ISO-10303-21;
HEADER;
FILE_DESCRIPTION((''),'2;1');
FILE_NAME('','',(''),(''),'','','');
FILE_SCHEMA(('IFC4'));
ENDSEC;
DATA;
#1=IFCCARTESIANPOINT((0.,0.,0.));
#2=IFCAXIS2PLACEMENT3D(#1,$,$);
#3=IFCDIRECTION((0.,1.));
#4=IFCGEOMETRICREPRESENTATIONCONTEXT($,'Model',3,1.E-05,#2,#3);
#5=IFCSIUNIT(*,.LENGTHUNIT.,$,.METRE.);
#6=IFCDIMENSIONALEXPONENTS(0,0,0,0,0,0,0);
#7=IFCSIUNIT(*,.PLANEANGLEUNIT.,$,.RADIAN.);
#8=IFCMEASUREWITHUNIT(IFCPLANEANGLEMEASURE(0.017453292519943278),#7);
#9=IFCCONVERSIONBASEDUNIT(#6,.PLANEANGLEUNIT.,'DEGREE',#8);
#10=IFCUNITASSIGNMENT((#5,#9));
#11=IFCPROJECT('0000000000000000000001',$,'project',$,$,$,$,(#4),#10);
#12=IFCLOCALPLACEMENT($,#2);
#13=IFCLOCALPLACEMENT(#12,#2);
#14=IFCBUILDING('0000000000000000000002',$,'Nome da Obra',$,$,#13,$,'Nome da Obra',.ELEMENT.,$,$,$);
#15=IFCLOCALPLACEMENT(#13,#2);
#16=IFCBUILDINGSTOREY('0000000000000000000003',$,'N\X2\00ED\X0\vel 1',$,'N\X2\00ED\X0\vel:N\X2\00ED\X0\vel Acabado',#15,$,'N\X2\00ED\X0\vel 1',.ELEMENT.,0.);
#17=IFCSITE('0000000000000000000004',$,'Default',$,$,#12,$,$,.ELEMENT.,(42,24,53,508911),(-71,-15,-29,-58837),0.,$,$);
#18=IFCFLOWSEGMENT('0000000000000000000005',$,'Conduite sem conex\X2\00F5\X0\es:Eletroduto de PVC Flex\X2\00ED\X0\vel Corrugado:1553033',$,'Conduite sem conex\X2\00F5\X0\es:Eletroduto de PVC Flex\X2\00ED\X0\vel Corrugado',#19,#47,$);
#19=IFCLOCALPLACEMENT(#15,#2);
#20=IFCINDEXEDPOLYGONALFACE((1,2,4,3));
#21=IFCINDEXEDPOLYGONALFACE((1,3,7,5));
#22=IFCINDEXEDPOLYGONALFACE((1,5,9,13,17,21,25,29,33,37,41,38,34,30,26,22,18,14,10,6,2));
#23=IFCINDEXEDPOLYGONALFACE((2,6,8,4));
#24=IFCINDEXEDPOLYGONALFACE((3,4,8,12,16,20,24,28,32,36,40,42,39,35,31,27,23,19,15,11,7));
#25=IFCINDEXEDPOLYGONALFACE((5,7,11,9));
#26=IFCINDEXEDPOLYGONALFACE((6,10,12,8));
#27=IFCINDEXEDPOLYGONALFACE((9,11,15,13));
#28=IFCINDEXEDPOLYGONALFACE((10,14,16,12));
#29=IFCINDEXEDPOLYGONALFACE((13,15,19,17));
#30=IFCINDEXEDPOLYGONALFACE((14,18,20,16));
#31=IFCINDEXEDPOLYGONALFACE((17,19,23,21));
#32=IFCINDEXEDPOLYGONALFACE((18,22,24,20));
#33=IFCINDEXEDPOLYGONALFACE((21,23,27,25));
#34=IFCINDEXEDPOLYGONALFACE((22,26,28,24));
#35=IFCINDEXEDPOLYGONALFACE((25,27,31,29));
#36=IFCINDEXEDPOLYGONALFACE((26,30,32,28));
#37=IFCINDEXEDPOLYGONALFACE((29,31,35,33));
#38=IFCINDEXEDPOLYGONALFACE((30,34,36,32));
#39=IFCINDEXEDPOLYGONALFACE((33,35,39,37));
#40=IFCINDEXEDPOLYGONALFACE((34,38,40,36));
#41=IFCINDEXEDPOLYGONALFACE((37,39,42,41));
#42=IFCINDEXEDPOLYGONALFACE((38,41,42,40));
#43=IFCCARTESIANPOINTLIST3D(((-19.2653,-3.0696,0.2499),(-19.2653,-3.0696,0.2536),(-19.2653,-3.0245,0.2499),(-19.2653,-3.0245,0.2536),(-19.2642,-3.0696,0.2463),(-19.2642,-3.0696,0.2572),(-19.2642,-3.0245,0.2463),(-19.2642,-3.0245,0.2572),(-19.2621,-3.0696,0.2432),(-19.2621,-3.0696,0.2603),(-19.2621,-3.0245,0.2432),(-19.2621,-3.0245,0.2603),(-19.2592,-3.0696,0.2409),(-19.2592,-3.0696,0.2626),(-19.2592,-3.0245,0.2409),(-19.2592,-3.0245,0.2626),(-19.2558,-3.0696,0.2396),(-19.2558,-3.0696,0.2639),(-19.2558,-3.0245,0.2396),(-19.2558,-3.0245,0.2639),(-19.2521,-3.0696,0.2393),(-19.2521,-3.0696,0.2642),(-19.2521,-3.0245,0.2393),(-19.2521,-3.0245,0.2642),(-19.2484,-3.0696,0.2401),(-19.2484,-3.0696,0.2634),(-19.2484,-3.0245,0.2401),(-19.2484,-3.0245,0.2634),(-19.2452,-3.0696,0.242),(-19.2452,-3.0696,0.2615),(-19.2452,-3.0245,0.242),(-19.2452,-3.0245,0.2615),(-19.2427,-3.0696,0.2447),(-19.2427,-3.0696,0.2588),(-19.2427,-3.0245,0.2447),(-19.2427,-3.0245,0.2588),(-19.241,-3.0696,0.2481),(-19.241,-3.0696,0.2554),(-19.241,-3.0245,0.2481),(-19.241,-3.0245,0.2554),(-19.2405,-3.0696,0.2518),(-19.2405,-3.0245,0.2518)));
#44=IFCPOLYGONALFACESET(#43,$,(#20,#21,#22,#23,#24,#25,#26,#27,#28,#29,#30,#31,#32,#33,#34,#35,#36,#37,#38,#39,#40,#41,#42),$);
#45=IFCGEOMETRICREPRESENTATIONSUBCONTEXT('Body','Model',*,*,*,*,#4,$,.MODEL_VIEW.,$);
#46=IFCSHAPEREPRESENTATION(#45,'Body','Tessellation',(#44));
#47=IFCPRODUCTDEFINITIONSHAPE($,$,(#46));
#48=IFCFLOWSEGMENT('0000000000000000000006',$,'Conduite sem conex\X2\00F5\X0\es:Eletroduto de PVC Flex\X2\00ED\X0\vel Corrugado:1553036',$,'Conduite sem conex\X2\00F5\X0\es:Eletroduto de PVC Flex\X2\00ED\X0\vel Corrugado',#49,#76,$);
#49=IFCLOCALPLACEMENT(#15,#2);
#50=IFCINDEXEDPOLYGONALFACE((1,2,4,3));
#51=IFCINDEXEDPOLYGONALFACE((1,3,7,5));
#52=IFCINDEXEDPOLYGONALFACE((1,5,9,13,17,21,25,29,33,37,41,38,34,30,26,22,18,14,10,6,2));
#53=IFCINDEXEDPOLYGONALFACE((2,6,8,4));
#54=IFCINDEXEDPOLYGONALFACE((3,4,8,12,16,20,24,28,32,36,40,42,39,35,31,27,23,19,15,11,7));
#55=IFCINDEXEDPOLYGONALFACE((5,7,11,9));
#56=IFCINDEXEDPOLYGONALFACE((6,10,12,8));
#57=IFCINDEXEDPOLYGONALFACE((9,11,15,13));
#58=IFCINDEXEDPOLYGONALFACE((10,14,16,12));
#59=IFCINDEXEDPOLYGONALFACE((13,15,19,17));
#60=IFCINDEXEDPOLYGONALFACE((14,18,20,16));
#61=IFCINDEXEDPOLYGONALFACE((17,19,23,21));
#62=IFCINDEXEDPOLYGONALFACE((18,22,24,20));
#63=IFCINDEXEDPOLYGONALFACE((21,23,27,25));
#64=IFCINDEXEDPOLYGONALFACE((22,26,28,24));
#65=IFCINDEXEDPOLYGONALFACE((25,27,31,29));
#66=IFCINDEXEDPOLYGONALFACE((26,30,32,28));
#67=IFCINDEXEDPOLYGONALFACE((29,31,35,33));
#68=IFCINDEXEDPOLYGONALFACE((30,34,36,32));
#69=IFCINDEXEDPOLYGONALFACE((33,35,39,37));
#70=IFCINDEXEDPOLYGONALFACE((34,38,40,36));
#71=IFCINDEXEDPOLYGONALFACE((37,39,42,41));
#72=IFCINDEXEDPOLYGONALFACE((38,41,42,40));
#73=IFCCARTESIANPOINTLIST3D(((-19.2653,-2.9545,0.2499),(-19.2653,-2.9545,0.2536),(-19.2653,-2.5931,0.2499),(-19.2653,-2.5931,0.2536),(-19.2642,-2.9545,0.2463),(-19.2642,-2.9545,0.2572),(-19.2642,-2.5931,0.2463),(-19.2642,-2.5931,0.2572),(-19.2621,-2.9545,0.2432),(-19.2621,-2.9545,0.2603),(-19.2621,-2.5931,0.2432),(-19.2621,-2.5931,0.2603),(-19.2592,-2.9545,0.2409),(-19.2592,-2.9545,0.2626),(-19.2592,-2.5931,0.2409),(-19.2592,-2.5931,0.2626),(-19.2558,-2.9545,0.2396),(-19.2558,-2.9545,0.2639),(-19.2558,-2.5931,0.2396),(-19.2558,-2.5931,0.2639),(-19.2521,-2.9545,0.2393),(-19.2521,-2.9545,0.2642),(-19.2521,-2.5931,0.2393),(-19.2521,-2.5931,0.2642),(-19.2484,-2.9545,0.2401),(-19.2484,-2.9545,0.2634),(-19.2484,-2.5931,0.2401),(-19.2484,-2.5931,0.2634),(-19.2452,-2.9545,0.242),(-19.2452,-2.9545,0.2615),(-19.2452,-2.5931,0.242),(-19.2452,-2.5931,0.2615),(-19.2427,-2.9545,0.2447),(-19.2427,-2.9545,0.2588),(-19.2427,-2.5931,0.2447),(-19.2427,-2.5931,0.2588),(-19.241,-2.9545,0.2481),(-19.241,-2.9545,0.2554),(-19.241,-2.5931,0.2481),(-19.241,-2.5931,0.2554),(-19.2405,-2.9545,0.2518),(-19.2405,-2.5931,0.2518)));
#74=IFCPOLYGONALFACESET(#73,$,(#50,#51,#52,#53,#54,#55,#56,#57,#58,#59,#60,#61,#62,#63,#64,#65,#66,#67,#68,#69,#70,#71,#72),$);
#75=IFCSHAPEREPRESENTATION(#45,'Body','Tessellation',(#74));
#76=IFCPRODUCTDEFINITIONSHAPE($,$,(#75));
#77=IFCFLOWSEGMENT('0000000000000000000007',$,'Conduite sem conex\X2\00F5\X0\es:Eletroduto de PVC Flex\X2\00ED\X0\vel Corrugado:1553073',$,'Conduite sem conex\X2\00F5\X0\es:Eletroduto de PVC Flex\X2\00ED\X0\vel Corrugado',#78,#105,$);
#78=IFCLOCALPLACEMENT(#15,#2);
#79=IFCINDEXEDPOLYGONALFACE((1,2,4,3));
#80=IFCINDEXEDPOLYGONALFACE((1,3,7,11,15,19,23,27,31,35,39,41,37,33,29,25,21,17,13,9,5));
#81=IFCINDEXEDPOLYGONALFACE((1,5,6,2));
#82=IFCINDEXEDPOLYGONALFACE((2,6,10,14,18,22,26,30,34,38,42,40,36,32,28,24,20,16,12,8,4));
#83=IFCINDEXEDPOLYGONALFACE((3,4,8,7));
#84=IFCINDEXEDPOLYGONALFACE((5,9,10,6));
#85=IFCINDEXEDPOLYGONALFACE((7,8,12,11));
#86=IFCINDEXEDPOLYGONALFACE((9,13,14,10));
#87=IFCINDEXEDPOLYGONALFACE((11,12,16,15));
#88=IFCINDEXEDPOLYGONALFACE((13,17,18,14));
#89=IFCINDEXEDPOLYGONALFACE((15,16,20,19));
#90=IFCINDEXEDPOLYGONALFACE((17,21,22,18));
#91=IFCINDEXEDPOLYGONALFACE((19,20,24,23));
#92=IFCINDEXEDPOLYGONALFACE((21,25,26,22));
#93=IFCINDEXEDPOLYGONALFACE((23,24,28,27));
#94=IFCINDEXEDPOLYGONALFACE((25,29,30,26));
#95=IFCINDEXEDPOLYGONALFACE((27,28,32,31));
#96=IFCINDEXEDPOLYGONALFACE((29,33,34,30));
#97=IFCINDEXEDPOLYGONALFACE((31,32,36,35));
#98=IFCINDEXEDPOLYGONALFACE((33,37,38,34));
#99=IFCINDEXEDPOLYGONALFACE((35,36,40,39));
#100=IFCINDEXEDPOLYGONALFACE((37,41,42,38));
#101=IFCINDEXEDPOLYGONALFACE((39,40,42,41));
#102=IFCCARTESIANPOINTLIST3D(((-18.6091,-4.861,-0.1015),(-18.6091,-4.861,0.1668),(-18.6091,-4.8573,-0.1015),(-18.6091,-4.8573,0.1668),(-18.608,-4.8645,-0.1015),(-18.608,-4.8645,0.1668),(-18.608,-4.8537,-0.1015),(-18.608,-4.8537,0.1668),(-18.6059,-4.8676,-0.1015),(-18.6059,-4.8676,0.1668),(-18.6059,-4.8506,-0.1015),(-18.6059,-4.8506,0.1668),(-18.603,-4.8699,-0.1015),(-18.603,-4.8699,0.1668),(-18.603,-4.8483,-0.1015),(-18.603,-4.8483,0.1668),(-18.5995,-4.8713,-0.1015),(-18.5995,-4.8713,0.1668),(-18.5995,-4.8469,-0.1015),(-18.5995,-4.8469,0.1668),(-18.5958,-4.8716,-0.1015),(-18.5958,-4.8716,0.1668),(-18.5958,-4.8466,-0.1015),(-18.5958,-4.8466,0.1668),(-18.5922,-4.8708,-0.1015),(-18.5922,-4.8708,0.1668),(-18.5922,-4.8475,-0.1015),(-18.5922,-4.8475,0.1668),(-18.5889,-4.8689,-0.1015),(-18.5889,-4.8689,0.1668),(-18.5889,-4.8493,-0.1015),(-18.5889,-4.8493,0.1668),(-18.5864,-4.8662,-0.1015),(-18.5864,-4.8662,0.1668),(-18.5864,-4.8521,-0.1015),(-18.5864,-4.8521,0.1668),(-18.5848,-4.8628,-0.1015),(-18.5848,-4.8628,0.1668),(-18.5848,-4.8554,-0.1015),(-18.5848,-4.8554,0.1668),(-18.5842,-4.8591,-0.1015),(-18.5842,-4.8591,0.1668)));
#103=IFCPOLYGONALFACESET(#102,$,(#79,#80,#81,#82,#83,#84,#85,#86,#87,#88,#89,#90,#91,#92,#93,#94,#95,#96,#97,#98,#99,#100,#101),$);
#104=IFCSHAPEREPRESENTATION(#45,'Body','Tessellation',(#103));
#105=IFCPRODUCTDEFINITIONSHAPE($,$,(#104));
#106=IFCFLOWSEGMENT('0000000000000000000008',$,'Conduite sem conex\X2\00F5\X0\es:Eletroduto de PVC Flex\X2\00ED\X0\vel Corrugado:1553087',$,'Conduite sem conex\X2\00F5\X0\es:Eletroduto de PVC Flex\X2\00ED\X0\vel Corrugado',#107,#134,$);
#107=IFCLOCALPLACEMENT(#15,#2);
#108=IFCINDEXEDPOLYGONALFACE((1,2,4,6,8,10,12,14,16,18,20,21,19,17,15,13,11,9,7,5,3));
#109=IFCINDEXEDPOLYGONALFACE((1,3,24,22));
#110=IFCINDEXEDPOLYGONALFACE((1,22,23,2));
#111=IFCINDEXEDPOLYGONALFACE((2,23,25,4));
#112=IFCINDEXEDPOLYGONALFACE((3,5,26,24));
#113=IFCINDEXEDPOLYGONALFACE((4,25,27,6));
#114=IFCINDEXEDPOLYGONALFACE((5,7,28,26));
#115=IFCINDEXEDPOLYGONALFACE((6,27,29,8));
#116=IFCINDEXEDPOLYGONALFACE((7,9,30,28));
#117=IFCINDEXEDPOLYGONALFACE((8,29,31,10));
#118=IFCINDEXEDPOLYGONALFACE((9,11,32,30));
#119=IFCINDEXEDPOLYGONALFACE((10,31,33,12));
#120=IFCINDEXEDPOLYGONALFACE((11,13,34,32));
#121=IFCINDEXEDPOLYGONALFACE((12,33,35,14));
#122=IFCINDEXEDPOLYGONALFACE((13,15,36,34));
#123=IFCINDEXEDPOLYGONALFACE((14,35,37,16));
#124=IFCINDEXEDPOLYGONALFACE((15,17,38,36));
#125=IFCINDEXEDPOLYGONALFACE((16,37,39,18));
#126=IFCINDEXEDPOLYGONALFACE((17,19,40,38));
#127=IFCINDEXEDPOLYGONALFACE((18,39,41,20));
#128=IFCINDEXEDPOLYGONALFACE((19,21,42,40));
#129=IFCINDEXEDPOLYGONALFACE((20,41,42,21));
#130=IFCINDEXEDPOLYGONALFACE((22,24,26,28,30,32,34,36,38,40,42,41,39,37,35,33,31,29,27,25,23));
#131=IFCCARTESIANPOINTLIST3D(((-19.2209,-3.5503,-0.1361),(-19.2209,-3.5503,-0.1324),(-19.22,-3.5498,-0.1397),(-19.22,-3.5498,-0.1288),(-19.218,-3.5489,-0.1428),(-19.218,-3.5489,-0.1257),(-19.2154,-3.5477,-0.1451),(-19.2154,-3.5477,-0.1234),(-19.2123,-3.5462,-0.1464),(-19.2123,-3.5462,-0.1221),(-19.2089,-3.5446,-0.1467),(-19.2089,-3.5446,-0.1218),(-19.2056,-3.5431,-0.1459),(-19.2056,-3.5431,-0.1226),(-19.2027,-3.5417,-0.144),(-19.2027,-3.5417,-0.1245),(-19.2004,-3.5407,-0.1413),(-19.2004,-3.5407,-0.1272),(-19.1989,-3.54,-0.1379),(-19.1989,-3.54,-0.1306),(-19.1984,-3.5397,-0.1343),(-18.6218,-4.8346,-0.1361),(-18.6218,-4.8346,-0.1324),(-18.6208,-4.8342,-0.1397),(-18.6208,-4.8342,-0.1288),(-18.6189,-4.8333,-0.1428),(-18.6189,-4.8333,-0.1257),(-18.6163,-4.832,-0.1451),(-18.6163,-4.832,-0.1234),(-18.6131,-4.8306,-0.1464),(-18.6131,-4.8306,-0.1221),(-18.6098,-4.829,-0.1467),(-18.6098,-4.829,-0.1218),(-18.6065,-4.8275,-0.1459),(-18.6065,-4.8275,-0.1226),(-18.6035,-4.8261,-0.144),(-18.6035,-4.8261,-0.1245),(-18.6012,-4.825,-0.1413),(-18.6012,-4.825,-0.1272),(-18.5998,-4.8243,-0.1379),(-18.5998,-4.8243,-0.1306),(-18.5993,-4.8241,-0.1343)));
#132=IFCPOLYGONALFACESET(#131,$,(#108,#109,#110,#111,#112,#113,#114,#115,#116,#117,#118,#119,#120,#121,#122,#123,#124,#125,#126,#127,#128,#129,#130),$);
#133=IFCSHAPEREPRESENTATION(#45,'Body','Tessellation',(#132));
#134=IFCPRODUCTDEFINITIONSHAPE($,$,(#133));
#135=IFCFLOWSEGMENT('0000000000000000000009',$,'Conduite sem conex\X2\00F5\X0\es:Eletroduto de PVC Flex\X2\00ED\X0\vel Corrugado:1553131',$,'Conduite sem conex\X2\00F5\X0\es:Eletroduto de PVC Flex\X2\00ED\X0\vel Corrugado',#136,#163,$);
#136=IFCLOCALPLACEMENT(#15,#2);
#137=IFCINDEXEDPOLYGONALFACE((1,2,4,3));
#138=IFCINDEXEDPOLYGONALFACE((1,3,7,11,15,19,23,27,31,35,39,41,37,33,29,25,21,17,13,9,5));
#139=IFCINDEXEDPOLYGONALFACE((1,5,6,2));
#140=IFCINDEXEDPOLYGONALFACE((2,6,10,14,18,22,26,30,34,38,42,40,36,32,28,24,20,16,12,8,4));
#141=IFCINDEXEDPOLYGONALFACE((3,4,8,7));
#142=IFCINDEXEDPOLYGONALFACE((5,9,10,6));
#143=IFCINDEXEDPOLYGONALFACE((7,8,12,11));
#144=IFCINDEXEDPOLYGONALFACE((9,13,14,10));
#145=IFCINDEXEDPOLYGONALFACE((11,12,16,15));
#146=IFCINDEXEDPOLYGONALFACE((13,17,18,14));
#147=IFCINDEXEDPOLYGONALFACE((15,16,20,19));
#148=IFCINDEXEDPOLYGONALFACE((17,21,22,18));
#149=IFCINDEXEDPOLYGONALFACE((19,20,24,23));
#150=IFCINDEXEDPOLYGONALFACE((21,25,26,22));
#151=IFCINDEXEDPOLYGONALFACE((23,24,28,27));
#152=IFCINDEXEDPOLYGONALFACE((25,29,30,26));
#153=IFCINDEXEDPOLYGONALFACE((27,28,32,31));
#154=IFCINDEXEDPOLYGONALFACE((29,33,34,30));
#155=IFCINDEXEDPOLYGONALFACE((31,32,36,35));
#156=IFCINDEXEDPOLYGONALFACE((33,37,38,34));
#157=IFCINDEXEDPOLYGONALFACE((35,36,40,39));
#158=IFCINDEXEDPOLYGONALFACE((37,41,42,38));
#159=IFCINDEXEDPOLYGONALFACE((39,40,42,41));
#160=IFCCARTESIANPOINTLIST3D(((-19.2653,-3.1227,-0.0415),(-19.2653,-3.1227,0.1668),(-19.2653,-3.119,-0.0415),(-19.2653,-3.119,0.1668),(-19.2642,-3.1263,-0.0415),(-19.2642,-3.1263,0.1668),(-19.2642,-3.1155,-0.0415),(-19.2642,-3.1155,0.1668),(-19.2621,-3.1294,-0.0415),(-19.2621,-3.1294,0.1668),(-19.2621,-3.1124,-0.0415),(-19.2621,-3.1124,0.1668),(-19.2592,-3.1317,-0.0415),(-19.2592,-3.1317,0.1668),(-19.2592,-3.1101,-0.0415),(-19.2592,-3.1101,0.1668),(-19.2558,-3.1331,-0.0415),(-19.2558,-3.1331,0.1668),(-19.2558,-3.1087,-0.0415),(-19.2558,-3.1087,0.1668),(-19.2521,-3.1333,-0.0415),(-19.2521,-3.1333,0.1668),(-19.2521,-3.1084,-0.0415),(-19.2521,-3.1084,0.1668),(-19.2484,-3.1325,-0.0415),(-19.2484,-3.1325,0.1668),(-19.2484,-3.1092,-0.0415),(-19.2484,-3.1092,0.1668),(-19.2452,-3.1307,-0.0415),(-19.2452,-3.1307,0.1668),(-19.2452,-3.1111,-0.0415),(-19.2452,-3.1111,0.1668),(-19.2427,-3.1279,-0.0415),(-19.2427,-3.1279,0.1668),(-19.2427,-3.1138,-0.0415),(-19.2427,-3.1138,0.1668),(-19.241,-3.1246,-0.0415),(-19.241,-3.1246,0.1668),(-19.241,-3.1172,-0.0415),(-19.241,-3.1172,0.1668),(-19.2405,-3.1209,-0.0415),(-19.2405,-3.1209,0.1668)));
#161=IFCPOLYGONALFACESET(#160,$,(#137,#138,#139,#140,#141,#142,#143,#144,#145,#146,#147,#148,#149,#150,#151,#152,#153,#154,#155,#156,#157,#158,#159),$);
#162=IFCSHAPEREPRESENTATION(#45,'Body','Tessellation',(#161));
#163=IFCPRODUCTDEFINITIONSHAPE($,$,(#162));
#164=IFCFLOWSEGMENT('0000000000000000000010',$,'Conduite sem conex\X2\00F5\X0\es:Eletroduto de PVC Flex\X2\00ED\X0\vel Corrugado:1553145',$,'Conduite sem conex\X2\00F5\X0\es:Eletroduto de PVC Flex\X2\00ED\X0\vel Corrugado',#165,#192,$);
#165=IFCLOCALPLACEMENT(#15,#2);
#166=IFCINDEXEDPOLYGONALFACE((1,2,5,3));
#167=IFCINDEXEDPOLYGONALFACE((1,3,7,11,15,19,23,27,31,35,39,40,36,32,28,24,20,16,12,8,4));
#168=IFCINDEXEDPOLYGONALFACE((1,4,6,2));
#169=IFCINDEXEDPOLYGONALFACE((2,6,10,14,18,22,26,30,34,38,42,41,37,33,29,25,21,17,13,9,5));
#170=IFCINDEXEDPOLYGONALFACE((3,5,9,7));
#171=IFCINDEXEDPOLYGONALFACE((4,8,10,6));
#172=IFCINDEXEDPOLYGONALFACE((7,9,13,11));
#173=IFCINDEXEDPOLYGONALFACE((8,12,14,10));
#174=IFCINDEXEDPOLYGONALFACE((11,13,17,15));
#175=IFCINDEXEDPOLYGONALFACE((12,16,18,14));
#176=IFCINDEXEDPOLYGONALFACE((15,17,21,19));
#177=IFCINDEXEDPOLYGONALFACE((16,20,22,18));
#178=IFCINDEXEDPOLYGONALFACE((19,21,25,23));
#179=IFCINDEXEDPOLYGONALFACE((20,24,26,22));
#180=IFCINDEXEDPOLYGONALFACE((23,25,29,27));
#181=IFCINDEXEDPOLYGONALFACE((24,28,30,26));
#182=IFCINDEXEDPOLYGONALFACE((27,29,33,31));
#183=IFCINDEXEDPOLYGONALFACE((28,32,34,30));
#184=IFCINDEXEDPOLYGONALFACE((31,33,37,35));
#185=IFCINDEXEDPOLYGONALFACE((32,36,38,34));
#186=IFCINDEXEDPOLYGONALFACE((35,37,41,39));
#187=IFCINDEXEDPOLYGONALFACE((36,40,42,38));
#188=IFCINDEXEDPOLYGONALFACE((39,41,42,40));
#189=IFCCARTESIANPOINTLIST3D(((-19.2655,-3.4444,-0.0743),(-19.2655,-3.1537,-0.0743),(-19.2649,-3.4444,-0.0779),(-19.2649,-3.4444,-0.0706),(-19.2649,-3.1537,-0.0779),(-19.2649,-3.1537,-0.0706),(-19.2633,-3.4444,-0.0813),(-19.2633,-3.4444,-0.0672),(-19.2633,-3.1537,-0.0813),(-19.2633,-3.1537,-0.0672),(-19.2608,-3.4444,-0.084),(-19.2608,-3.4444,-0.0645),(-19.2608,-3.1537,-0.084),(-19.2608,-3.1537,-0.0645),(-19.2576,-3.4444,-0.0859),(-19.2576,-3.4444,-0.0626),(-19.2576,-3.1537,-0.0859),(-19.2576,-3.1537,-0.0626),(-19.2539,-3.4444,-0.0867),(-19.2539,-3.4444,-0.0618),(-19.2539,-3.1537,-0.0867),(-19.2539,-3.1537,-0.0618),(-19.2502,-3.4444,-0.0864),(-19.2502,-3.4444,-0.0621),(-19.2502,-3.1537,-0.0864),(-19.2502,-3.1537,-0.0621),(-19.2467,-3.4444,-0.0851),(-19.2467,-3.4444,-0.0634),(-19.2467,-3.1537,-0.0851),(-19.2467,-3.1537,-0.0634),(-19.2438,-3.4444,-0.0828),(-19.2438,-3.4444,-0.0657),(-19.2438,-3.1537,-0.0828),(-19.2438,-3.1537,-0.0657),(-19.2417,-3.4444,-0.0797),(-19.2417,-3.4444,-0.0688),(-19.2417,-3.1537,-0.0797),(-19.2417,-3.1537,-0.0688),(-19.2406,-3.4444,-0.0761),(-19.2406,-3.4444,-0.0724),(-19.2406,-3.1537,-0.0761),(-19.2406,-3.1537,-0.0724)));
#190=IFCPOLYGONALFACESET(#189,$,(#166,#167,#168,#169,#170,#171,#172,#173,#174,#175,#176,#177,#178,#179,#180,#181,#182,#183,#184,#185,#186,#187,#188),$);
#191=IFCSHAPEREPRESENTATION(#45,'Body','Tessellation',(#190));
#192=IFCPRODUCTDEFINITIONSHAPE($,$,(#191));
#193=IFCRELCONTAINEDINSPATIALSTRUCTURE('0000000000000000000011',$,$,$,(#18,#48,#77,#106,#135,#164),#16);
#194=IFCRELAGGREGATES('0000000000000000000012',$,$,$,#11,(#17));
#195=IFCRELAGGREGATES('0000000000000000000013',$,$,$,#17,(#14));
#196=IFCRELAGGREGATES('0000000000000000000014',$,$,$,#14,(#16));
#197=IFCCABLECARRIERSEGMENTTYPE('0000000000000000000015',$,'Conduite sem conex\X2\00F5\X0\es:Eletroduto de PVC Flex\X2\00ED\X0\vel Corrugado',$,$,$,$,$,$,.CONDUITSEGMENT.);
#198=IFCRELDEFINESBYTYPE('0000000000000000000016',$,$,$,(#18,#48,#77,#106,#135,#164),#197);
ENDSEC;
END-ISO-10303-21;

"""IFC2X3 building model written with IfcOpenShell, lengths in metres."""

from ifc_helpers import new_model, entity, si_unit, converted_unit, direction, frame, frame_2d, origin, origin_2d_with_axis, place, context, subcontext, project, spatial, circle, extrude, type_object, element, save


model = new_model("IFC2X3")

# Units and contexts
model_context = context("Model", 3, precision=1e-05, world=origin(), true_north=direction((0.0, 1.0)))
body_context = subcontext(model_context, "Body", "Model", "MODEL_VIEW")
ifc_project = project(units=[si_unit("LENGTHUNIT", "METRE"), converted_unit("PLANEANGLEUNIT", "DEGREE", entity("IfcPlaneAngleMeasure", 0.017453292519943278), si_unit("PLANEANGLEUNIT", "RADIAN"), dimensions=[0, 0, 0, 0, 0, 0, 0])], contexts=[model_context])

# Site, building, storey
site_placement = place(None, origin())
site = spatial("IfcSite", under=ifc_project, at=site_placement, Name="Default", CompositionType="ELEMENT", RefLatitude=(42, 24, 53, 508911), RefLongitude=(-71, -15, -29, -58837), RefElevation=0.0)
building_placement = place(site_placement, origin())
building = spatial("IfcBuilding", under=site, at=building_placement, Name="Nome da Obra", LongName="Nome da Obra", CompositionType="ELEMENT")
storey_placement = place(building_placement, origin())
storey = spatial("IfcBuildingStorey", under=building, at=storey_placement, Name="Nível 1", ObjectType="Nível:Nível Acabado", LongName="Nível 1", CompositionType="ELEMENT", Elevation=0.0)

# Flow segments
cable_carrier_segment_type = type_object("IfcCableCarrierSegmentType", Name="Conduite sem conexões:Eletroduto de PVC Flexível Corrugado", PredefinedType="CONDUITSEGMENT")
flow_segment_1_placement = place(storey_placement, origin())
element("IfcFlowSegment", 1, at=flow_segment_1_placement, inside=storey, type_object=cable_carrier_segment_type, Name="Conduite sem conexões:Eletroduto de PVC Flexível Corrugado:1553033", ObjectType="Conduite sem conexões:Eletroduto de PVC Flexível Corrugado", context=body_context, shape_type="SweptSolid", body=[
    extrude(circle(Radius=0.0125, at=origin_2d_with_axis()), frame((-19.253, -3.0696, 0.2518), z_axis=(0.0, 1.0, 0.0), x_axis=(1.0, 0.0, 0.0)), (0.0, 0.0, 1.0), 0.0451),
])
flow_segment_2_placement = place(storey_placement, origin())
element("IfcFlowSegment", 2, at=flow_segment_2_placement, inside=storey, type_object=cable_carrier_segment_type, Name="Conduite sem conexões:Eletroduto de PVC Flexível Corrugado:1553036", ObjectType="Conduite sem conexões:Eletroduto de PVC Flexível Corrugado", context=body_context, shape_type="SweptSolid", body=[
    extrude(circle(Radius=0.0125, at=origin_2d_with_axis()), frame((-19.253, -2.9545, 0.2518), z_axis=(0.0, 1.0, 0.0), x_axis=(1.0, 0.0, 0.0)), (0.0, 0.0, 1.0), 0.3614),
])
flow_segment_3_placement = place(storey_placement, origin())
element("IfcFlowSegment", 3, at=flow_segment_3_placement, inside=storey, type_object=cable_carrier_segment_type, Name="Conduite sem conexões:Eletroduto de PVC Flexível Corrugado:1553073", ObjectType="Conduite sem conexões:Eletroduto de PVC Flexível Corrugado", context=body_context, shape_type="SweptSolid", body=[
    extrude(circle(Radius=0.0125, at=frame_2d((0.0, 0.0), x_axis=(1.0, 0.0))), frame((-18.5967, -4.8591, -0.1015)), (0.0, 0.0, 1.0), 0.2682),
])
flow_segment_4_placement = place(storey_placement, origin())
element("IfcFlowSegment", 4, at=flow_segment_4_placement, inside=storey, type_object=cable_carrier_segment_type, Name="Conduite sem conexões:Eletroduto de PVC Flexível Corrugado:1553087", ObjectType="Conduite sem conexões:Eletroduto de PVC Flexível Corrugado", context=body_context, shape_type="SweptSolid", body=[
    extrude(circle(Radius=0.0125, at=frame_2d((0.0, 0.0), x_axis=(1.0, 0.0))), frame((-19.2097, -3.545, -0.1343), z_axis=(0.422752, -0.906246, 0.0), x_axis=(0.906246, 0.422752, 0.0)), (0.0, 0.0, 1.0), 1.4172),
])
flow_segment_5_placement = place(storey_placement, origin())
element("IfcFlowSegment", 5, at=flow_segment_5_placement, inside=storey, type_object=cable_carrier_segment_type, Name="Conduite sem conexões:Eletroduto de PVC Flexível Corrugado:1553131", ObjectType="Conduite sem conexões:Eletroduto de PVC Flexível Corrugado", context=body_context, shape_type="SweptSolid", body=[
    extrude(circle(Radius=0.0125, at=frame_2d((0.0, 0.0), x_axis=(1.0, 0.0))), frame((-19.253, -3.1209, -0.0415)), (0.0, 0.0, 1.0), 0.2082),
])
flow_segment_6_placement = place(storey_placement, origin())
element("IfcFlowSegment", 6, at=flow_segment_6_placement, inside=storey, type_object=cable_carrier_segment_type, Name="Conduite sem conexões:Eletroduto de PVC Flexível Corrugado:1553145", ObjectType="Conduite sem conexões:Eletroduto de PVC Flexível Corrugado", context=body_context, shape_type="SweptSolid", body=[
    extrude(circle(Radius=0.0125, at=frame_2d((0.0, 0.0), x_axis=(1.0, 0.0))), frame((-19.253, -3.4444, -0.0743), z_axis=(0.0, 1.0, 0.0), x_axis=(-1.0, 0.0, 0.0)), (0.0, 0.0, 1.0), 0.2908),
])

save(model, "model.ifc")
